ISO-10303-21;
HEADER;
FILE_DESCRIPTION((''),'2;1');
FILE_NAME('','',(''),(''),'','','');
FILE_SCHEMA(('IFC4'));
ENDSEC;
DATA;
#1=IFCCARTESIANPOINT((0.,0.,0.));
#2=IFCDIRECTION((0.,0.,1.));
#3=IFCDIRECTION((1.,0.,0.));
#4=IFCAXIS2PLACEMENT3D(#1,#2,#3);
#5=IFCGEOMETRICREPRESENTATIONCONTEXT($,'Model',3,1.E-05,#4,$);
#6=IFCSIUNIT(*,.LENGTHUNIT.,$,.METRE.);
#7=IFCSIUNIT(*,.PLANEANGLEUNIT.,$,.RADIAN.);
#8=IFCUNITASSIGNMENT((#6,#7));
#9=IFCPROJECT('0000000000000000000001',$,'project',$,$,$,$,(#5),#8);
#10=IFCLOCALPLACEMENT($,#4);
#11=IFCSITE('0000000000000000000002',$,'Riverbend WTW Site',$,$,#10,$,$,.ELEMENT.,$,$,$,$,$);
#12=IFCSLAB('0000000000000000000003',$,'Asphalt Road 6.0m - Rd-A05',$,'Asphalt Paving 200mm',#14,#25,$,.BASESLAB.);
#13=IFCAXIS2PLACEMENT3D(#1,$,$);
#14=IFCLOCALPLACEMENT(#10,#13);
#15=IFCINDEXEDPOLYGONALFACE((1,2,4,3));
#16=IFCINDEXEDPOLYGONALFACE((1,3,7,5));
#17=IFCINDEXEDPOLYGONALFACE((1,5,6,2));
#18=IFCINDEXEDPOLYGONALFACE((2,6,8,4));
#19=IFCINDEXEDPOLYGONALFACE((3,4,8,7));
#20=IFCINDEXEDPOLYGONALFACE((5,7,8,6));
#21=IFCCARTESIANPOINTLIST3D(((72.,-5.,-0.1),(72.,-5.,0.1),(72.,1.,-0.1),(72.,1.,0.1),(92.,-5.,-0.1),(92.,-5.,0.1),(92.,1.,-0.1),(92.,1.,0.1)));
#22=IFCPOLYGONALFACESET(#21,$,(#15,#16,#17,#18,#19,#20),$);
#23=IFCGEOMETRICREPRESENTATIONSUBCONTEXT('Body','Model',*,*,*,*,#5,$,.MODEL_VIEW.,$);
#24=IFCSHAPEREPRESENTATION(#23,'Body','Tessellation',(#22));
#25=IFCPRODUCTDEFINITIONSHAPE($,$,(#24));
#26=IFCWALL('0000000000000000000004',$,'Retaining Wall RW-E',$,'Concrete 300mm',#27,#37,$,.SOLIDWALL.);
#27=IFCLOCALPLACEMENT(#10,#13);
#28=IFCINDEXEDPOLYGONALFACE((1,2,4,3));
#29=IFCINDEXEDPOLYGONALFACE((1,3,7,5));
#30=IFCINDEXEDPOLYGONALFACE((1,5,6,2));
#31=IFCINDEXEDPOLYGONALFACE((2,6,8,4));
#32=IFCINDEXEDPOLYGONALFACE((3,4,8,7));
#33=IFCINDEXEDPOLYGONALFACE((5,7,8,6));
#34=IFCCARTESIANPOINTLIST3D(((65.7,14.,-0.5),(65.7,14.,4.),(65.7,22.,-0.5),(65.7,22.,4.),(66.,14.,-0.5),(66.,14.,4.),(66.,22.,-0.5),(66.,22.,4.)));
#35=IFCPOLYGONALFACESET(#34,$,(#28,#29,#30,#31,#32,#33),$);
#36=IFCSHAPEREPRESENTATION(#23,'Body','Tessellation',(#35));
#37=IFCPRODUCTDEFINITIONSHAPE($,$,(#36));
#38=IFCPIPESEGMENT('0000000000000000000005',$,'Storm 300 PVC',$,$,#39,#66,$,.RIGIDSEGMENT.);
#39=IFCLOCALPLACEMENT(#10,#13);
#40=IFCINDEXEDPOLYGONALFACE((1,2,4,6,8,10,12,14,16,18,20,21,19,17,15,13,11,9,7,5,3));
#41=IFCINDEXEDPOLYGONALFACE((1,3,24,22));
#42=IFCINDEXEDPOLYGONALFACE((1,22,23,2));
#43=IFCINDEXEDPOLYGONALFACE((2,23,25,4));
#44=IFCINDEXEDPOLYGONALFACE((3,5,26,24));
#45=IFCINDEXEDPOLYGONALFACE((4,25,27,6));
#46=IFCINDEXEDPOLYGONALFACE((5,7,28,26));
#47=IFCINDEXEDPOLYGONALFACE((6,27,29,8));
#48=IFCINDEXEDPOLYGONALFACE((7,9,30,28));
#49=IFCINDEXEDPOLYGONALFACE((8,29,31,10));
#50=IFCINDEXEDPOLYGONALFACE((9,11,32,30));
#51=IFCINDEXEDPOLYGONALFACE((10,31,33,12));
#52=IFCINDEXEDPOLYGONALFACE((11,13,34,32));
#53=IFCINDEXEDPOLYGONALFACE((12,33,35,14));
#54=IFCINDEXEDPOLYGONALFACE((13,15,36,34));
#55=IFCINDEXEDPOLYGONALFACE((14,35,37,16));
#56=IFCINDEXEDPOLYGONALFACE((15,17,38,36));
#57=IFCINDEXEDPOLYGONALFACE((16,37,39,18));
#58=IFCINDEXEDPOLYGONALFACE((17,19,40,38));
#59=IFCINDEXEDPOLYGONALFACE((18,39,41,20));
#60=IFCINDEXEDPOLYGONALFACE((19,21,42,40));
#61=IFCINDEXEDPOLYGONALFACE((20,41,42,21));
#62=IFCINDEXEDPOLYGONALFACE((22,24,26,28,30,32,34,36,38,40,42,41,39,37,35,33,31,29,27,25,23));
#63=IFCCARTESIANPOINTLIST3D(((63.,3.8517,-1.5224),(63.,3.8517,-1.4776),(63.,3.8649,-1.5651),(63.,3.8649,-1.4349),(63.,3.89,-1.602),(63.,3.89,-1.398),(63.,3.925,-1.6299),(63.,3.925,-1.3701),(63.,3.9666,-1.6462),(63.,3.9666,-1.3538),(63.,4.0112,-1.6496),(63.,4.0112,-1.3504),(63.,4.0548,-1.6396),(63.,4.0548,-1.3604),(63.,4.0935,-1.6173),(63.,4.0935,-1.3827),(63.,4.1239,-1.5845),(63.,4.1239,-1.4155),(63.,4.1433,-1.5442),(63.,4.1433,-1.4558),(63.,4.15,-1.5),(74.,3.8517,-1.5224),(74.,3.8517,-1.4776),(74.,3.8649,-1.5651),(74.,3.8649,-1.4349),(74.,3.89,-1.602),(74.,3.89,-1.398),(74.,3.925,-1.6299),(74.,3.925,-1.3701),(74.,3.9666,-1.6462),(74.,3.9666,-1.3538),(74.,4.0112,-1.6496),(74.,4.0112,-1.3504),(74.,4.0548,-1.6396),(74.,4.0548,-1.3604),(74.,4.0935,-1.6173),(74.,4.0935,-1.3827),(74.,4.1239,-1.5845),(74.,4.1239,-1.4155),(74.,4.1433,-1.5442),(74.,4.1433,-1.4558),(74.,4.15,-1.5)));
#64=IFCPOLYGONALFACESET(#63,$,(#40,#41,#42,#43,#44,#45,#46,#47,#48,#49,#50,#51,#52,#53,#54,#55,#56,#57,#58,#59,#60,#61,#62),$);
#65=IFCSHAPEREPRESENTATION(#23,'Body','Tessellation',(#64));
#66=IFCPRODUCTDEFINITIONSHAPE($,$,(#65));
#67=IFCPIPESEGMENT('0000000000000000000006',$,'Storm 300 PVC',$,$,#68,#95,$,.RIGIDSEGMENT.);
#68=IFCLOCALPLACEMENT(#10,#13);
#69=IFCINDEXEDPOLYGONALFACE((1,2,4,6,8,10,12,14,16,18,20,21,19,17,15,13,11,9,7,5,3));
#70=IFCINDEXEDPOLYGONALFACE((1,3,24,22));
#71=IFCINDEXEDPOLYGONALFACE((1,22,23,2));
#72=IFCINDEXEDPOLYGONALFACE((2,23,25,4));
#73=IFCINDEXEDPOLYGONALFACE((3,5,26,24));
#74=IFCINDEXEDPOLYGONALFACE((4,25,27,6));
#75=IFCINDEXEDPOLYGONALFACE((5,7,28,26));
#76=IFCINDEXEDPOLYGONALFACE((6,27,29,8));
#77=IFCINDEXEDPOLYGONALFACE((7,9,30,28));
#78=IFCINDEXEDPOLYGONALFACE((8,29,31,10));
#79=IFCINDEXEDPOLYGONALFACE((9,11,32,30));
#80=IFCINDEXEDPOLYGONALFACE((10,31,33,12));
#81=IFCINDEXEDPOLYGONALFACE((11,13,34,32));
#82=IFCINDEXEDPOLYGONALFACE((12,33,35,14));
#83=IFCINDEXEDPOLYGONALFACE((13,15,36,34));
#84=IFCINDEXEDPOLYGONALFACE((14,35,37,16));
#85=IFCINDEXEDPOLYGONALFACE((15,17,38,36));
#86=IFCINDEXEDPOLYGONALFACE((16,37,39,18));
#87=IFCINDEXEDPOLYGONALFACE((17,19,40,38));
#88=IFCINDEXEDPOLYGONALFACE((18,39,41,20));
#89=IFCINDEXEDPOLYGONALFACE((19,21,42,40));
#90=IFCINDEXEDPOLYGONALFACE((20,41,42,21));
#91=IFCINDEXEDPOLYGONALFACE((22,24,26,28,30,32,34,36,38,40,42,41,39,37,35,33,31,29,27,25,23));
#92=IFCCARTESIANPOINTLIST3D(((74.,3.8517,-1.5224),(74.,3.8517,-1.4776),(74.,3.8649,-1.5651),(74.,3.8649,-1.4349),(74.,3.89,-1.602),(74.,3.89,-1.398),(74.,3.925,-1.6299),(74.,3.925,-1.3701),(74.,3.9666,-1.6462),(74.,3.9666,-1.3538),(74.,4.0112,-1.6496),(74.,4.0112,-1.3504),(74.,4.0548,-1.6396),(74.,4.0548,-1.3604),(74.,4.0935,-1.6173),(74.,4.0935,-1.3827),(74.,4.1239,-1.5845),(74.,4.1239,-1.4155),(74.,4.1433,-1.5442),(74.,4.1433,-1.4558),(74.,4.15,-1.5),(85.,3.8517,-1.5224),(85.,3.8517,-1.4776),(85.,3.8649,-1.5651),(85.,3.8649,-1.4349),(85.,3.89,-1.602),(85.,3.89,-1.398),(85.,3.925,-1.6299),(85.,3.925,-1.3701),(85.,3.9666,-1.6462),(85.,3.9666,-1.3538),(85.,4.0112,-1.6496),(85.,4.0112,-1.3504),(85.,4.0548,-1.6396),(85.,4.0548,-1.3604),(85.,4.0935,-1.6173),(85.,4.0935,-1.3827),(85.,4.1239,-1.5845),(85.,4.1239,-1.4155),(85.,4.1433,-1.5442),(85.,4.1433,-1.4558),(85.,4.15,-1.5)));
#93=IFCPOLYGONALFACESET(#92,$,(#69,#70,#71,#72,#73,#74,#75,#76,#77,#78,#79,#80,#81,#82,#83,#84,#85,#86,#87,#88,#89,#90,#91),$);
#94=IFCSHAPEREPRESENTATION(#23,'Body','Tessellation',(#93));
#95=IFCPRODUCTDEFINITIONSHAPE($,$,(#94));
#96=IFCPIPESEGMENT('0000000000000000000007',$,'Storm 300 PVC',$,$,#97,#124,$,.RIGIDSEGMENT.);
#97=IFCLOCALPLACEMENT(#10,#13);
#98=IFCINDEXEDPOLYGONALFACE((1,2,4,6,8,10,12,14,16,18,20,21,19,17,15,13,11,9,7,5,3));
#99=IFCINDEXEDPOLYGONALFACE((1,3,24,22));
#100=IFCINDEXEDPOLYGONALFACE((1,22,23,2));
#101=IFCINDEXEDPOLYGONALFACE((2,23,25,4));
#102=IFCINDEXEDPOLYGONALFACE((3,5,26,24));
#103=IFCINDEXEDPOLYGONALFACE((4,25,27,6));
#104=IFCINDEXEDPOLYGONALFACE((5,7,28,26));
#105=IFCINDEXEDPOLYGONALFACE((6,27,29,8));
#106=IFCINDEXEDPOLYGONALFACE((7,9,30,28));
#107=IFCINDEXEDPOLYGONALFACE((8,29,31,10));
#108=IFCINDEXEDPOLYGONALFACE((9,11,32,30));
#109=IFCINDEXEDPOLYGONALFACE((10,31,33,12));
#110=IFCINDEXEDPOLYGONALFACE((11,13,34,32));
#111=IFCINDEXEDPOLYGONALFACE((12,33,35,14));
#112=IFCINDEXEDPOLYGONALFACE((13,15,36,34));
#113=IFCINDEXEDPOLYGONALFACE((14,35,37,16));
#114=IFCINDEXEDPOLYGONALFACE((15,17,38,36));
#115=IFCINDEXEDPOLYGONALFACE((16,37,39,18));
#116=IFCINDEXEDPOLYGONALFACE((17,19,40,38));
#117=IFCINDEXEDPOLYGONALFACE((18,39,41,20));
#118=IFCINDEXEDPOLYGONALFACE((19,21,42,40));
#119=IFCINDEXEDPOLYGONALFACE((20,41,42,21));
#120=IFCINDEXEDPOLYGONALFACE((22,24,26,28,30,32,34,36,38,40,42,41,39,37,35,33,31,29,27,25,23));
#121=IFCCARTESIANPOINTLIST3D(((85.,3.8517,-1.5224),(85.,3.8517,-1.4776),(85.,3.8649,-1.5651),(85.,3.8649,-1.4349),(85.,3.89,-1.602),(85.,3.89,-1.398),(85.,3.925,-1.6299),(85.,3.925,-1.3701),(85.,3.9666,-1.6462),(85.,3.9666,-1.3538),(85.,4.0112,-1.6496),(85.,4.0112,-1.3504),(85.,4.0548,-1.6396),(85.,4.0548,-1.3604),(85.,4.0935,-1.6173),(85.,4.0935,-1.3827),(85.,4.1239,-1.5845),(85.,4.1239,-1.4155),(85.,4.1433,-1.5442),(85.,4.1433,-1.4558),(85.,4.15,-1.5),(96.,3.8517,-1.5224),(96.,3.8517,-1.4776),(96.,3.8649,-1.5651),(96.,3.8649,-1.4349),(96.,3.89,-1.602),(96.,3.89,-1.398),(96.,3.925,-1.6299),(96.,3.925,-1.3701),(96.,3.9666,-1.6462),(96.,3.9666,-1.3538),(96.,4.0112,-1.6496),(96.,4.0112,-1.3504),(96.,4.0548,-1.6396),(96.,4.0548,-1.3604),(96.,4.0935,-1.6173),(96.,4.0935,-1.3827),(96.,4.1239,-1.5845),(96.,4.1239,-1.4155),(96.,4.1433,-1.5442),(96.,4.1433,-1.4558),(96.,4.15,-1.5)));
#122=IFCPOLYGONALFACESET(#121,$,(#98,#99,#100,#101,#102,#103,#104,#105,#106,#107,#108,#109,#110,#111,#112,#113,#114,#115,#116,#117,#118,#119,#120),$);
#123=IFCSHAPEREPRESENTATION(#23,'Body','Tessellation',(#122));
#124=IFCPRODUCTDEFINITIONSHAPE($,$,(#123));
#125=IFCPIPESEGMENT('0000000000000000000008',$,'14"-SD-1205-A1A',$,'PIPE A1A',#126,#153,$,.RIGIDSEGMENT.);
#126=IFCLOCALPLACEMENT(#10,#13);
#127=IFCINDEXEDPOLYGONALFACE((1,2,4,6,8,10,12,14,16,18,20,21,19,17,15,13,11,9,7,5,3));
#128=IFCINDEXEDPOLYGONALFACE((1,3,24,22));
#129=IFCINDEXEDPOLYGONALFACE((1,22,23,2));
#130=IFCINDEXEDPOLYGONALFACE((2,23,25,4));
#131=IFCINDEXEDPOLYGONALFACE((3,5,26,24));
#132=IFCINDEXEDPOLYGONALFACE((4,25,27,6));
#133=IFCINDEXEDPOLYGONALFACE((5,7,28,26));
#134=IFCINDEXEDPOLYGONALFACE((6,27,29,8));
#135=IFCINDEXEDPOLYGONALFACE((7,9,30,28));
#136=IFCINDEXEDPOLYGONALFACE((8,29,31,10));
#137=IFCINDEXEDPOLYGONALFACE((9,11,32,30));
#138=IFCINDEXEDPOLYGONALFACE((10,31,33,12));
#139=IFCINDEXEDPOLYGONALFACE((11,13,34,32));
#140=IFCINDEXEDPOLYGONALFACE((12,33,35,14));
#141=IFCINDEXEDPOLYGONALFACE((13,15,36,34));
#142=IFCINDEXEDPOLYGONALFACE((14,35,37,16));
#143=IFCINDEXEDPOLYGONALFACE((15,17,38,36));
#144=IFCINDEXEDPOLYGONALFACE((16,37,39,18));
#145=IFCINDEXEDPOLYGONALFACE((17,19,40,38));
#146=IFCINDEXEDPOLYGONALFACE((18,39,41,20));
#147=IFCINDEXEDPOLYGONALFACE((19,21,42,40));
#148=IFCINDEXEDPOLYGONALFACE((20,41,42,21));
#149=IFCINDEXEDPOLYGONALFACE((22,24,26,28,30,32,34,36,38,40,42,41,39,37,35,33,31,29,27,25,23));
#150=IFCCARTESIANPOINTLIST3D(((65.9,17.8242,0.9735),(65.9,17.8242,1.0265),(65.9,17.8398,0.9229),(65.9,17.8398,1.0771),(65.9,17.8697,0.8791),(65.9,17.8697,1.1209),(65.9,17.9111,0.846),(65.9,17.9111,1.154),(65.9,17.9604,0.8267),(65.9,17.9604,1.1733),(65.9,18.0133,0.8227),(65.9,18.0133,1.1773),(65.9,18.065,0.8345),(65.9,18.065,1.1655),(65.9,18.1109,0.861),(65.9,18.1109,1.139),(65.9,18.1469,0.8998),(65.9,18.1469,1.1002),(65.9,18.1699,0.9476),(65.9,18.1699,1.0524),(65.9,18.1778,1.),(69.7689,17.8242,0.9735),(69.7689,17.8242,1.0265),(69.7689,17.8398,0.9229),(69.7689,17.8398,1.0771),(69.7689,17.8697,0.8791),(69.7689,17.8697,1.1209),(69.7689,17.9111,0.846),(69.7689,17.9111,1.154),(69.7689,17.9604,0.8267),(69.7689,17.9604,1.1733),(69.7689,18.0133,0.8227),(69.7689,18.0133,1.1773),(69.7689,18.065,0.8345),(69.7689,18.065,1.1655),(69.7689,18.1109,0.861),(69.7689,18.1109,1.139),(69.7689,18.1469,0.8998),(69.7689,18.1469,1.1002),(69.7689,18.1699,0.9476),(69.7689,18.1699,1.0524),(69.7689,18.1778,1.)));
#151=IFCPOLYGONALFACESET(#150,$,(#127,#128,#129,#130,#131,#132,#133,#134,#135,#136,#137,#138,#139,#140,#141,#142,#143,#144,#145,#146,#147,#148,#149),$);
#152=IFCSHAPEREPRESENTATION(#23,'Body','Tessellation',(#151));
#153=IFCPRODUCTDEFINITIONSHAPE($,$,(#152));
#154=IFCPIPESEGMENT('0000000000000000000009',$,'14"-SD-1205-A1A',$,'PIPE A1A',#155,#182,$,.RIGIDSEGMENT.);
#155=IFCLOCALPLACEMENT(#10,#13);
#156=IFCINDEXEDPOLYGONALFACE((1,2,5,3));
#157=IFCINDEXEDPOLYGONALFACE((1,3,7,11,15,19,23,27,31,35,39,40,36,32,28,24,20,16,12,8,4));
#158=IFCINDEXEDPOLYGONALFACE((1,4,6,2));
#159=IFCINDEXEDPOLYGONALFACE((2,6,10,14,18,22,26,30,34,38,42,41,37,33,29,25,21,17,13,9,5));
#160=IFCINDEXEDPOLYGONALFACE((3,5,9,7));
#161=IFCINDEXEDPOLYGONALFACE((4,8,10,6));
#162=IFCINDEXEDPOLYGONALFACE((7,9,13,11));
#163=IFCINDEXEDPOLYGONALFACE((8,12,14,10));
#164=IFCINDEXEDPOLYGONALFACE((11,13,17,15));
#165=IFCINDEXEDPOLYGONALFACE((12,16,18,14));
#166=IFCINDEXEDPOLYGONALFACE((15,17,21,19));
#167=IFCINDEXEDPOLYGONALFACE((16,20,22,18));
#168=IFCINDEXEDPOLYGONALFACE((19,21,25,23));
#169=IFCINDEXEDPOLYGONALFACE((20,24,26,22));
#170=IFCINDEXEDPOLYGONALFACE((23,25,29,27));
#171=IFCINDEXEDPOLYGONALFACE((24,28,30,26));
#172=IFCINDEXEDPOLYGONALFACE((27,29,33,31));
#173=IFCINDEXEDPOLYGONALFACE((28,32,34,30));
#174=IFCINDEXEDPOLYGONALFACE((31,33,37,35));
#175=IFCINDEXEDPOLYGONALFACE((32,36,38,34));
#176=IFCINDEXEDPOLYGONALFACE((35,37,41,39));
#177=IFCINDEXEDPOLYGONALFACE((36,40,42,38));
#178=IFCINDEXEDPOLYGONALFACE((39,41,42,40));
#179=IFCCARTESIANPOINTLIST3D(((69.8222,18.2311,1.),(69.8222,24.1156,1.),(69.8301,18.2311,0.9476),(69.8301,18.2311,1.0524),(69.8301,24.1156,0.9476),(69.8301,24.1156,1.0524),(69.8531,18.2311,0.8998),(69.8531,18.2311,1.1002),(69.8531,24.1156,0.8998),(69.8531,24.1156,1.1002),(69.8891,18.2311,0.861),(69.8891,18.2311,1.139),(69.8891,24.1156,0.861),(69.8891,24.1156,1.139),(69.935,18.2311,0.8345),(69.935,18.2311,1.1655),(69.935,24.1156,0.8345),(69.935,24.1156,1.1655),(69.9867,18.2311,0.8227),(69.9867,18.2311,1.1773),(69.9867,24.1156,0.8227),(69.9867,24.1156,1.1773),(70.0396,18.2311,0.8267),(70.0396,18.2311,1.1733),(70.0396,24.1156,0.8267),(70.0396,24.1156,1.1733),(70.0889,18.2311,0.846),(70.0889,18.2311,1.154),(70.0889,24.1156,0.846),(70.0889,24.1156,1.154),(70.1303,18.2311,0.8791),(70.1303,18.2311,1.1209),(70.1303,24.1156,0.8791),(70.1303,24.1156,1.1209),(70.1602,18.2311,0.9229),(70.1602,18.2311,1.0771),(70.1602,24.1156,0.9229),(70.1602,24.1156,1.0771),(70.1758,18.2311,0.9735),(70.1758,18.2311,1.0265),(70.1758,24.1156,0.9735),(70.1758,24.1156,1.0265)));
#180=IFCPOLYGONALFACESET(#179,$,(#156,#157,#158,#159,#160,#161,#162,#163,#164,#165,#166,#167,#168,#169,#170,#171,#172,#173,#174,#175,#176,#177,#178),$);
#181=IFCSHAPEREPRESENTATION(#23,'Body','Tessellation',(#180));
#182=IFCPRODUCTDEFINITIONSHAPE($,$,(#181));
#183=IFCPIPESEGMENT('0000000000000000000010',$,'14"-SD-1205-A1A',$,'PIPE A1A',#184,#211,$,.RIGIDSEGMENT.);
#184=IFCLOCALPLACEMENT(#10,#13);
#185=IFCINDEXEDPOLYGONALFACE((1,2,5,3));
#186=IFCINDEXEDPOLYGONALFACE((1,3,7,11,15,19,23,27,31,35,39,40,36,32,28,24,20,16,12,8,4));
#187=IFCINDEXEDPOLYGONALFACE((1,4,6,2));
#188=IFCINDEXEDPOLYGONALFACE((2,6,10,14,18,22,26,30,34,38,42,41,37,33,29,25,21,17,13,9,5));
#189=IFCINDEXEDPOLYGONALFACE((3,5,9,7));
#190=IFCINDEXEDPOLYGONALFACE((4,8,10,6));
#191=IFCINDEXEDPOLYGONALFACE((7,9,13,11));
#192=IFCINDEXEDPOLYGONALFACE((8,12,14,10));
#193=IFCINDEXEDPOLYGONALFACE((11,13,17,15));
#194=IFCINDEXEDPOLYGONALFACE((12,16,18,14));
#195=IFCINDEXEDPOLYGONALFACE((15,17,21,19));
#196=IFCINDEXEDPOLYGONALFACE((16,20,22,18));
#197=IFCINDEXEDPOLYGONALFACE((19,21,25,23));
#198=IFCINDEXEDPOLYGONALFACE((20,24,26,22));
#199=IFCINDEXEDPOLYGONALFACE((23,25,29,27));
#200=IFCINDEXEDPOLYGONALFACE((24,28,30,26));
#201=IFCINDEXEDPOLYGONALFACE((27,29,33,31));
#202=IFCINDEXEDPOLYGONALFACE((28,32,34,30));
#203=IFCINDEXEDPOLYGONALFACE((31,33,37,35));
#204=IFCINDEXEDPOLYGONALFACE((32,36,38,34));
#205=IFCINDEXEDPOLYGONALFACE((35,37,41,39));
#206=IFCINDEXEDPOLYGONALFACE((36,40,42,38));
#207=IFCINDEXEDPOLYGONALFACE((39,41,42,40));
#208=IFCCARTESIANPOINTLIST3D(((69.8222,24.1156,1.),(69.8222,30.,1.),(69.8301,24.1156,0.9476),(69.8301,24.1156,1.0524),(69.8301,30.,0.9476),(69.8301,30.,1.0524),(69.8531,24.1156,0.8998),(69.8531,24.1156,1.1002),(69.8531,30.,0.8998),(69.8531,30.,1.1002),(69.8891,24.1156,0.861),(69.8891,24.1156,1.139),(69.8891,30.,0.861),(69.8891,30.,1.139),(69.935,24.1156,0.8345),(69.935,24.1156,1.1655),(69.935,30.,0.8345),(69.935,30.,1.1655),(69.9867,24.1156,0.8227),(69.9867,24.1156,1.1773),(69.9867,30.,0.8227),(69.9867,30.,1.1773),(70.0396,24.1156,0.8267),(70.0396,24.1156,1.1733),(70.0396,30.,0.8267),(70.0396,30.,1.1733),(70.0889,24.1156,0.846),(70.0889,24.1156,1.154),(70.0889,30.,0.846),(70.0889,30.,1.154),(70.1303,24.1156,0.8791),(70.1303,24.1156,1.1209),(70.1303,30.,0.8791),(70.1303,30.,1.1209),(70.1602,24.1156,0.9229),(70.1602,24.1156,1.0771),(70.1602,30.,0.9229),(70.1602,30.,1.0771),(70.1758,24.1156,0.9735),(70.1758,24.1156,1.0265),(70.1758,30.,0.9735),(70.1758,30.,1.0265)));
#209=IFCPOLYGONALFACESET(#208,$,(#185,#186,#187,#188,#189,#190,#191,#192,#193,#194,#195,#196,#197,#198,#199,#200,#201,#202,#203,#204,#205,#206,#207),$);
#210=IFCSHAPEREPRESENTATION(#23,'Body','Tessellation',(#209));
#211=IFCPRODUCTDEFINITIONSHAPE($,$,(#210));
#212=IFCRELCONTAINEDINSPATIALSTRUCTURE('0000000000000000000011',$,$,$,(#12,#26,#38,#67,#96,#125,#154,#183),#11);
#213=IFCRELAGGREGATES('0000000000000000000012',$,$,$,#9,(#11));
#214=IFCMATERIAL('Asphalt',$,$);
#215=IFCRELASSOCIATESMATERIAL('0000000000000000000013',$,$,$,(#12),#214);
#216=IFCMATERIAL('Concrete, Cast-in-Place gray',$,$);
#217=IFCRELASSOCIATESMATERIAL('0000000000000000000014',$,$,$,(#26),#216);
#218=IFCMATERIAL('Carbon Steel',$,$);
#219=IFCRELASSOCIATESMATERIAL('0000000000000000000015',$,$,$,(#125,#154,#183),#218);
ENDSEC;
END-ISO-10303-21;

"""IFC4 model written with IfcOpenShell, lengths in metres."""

from ifc_helpers import new_model, si_unit, frame, origin_with_axes, origin_2d, place, context, subcontext, project, spatial, rectangle, circle, extrude, material, element, save


model = new_model("IFC4")

# Units and contexts
model_context = context("Model", 3, precision=1e-05, world=origin_with_axes())
body_context = subcontext(model_context, "Body", "Model", "MODEL_VIEW")
ifc_project = project(units=[si_unit("LENGTHUNIT", "METRE"), si_unit("PLANEANGLEUNIT", "RADIAN")], contexts=[model_context])

# Site
site_placement = place(None, origin_with_axes())
site = spatial("IfcSite", under=ifc_project, at=site_placement, Name="Riverbend WTW Site", CompositionType="ELEMENT")

# Slab
ifc_material_1 = material(Name="Asphalt")
slab_placement = place(None, frame((82.0, -2.0, 0.0), z_axis=(0.0, 0.0, 1.0), x_axis=(1.0, 0.0, 0.0)))
element("IfcSlab", 1, at=slab_placement, inside=site, material=ifc_material_1, Name="Asphalt Road 6.0m - Rd-A05", ObjectType="Asphalt Paving 200mm", PredefinedType="BASESLAB", context=body_context, shape_type="SweptSolid", body=[
    extrude(rectangle(XDim=20.0, YDim=6.0, at=origin_2d()), frame((0.0, 0.0, -0.1), z_axis=(0.0, 0.0, 1.0), x_axis=(1.0, 0.0, 0.0)), (0.0, 0.0, 1.0), 0.2),
])

# Wall
ifc_material_2 = material(Name="Concrete, Cast-in-Place gray")
wall_placement = place(None, frame((65.85, 18.0, 1.75), z_axis=(0.0, 0.0, 1.0), x_axis=(1.0, 0.0, 0.0)))
element("IfcWall", 2, at=wall_placement, inside=site, material=ifc_material_2, Name="Retaining Wall RW-E", ObjectType="Concrete 300mm", PredefinedType="SOLIDWALL", context=body_context, shape_type="SweptSolid", body=[
    extrude(rectangle(XDim=0.3, YDim=8.0, at=origin_2d()), frame((0.0, 0.0, -2.25), z_axis=(0.0, 0.0, 1.0), x_axis=(1.0, 0.0, 0.0)), (0.0, 0.0, 1.0), 4.5),
])

# Pipe segments
for number, where, z_axis, x_axis, name in (
    (3, (63.0, 4.0, -1.5), (0.0, 0.0, 1.0), (1.0, 0.0, 0.0), "Storm 300 PVC"),
    (4, (74.0, 4.0, -1.5), (0.0, 0.0, 1.0), (1.0, 0.0, 0.0), "Storm 300 PVC"),
    (5, (85.0, 4.0, -1.5), (0.0, 0.0, 1.0), (1.0, 0.0, 0.0), "Storm 300 PVC"),
):
    element("IfcPipeSegment", number, at=place(None, frame(where, z_axis=z_axis, x_axis=x_axis)), inside=site, Name=name, PredefinedType="RIGIDSEGMENT", context=body_context, shape_type="SweptSolid", body=[
        extrude(circle(Radius=0.15, at=origin_2d()), frame((0.0, 0.0, 0.0), z_axis=(1.0, 0.0, 0.0), x_axis=(0.0, 1.0, 0.0)), (0.0, 0.0, 1.0), 11.0),
    ])
ifc_material_3 = material(Name="Carbon Steel")
pipe_segment_1_placement = place(None, frame((65.9, 18.0, 1.0), z_axis=(0.0, 0.0, 1.0), x_axis=(1.0, 0.0, 0.0)))
element("IfcPipeSegment", 6, at=pipe_segment_1_placement, inside=site, material=ifc_material_3, Name="14\"-SD-1205-A1A", ObjectType="PIPE A1A", PredefinedType="RIGIDSEGMENT", context=body_context, shape_type="SweptSolid", body=[
    extrude(circle(Radius=0.1778, at=origin_2d()), frame((0.0, 0.0, 0.0), z_axis=(1.0, 0.0, 0.0), x_axis=(0.0, 1.0, 0.0)), (0.0, 0.0, 1.0), 3.8689),
])
pipe_segment_2_placement = place(None, frame((70.0, 18.2311, 1.0), z_axis=(0.0, 0.0, 1.0), x_axis=(1.0, 0.0, 0.0)))
element("IfcPipeSegment", 7, at=pipe_segment_2_placement, inside=site, material=ifc_material_3, Name="14\"-SD-1205-A1A", ObjectType="PIPE A1A", PredefinedType="RIGIDSEGMENT", context=body_context, shape_type="SweptSolid", body=[
    extrude(circle(Radius=0.1778, at=origin_2d()), frame((0.0, 0.0, 0.0), z_axis=(0.0, 1.0, 0.0), x_axis=(-1.0, 0.0, 0.0)), (0.0, 0.0, 1.0), 5.8844),
])
pipe_segment_3_placement = place(None, frame((70.0, 24.1156, 1.0), z_axis=(0.0, 0.0, 1.0), x_axis=(1.0, 0.0, 0.0)))
element("IfcPipeSegment", 8, at=pipe_segment_3_placement, inside=site, material=ifc_material_3, Name="14\"-SD-1205-A1A", ObjectType="PIPE A1A", PredefinedType="RIGIDSEGMENT", context=body_context, shape_type="SweptSolid", body=[
    extrude(circle(Radius=0.1778, at=origin_2d()), frame((0.0, 0.0, 0.0), z_axis=(0.0, 1.0, 0.0), x_axis=(-1.0, 0.0, 0.0)), (0.0, 0.0, 1.0), 5.8844),
])

save(model, "model.ifc")
